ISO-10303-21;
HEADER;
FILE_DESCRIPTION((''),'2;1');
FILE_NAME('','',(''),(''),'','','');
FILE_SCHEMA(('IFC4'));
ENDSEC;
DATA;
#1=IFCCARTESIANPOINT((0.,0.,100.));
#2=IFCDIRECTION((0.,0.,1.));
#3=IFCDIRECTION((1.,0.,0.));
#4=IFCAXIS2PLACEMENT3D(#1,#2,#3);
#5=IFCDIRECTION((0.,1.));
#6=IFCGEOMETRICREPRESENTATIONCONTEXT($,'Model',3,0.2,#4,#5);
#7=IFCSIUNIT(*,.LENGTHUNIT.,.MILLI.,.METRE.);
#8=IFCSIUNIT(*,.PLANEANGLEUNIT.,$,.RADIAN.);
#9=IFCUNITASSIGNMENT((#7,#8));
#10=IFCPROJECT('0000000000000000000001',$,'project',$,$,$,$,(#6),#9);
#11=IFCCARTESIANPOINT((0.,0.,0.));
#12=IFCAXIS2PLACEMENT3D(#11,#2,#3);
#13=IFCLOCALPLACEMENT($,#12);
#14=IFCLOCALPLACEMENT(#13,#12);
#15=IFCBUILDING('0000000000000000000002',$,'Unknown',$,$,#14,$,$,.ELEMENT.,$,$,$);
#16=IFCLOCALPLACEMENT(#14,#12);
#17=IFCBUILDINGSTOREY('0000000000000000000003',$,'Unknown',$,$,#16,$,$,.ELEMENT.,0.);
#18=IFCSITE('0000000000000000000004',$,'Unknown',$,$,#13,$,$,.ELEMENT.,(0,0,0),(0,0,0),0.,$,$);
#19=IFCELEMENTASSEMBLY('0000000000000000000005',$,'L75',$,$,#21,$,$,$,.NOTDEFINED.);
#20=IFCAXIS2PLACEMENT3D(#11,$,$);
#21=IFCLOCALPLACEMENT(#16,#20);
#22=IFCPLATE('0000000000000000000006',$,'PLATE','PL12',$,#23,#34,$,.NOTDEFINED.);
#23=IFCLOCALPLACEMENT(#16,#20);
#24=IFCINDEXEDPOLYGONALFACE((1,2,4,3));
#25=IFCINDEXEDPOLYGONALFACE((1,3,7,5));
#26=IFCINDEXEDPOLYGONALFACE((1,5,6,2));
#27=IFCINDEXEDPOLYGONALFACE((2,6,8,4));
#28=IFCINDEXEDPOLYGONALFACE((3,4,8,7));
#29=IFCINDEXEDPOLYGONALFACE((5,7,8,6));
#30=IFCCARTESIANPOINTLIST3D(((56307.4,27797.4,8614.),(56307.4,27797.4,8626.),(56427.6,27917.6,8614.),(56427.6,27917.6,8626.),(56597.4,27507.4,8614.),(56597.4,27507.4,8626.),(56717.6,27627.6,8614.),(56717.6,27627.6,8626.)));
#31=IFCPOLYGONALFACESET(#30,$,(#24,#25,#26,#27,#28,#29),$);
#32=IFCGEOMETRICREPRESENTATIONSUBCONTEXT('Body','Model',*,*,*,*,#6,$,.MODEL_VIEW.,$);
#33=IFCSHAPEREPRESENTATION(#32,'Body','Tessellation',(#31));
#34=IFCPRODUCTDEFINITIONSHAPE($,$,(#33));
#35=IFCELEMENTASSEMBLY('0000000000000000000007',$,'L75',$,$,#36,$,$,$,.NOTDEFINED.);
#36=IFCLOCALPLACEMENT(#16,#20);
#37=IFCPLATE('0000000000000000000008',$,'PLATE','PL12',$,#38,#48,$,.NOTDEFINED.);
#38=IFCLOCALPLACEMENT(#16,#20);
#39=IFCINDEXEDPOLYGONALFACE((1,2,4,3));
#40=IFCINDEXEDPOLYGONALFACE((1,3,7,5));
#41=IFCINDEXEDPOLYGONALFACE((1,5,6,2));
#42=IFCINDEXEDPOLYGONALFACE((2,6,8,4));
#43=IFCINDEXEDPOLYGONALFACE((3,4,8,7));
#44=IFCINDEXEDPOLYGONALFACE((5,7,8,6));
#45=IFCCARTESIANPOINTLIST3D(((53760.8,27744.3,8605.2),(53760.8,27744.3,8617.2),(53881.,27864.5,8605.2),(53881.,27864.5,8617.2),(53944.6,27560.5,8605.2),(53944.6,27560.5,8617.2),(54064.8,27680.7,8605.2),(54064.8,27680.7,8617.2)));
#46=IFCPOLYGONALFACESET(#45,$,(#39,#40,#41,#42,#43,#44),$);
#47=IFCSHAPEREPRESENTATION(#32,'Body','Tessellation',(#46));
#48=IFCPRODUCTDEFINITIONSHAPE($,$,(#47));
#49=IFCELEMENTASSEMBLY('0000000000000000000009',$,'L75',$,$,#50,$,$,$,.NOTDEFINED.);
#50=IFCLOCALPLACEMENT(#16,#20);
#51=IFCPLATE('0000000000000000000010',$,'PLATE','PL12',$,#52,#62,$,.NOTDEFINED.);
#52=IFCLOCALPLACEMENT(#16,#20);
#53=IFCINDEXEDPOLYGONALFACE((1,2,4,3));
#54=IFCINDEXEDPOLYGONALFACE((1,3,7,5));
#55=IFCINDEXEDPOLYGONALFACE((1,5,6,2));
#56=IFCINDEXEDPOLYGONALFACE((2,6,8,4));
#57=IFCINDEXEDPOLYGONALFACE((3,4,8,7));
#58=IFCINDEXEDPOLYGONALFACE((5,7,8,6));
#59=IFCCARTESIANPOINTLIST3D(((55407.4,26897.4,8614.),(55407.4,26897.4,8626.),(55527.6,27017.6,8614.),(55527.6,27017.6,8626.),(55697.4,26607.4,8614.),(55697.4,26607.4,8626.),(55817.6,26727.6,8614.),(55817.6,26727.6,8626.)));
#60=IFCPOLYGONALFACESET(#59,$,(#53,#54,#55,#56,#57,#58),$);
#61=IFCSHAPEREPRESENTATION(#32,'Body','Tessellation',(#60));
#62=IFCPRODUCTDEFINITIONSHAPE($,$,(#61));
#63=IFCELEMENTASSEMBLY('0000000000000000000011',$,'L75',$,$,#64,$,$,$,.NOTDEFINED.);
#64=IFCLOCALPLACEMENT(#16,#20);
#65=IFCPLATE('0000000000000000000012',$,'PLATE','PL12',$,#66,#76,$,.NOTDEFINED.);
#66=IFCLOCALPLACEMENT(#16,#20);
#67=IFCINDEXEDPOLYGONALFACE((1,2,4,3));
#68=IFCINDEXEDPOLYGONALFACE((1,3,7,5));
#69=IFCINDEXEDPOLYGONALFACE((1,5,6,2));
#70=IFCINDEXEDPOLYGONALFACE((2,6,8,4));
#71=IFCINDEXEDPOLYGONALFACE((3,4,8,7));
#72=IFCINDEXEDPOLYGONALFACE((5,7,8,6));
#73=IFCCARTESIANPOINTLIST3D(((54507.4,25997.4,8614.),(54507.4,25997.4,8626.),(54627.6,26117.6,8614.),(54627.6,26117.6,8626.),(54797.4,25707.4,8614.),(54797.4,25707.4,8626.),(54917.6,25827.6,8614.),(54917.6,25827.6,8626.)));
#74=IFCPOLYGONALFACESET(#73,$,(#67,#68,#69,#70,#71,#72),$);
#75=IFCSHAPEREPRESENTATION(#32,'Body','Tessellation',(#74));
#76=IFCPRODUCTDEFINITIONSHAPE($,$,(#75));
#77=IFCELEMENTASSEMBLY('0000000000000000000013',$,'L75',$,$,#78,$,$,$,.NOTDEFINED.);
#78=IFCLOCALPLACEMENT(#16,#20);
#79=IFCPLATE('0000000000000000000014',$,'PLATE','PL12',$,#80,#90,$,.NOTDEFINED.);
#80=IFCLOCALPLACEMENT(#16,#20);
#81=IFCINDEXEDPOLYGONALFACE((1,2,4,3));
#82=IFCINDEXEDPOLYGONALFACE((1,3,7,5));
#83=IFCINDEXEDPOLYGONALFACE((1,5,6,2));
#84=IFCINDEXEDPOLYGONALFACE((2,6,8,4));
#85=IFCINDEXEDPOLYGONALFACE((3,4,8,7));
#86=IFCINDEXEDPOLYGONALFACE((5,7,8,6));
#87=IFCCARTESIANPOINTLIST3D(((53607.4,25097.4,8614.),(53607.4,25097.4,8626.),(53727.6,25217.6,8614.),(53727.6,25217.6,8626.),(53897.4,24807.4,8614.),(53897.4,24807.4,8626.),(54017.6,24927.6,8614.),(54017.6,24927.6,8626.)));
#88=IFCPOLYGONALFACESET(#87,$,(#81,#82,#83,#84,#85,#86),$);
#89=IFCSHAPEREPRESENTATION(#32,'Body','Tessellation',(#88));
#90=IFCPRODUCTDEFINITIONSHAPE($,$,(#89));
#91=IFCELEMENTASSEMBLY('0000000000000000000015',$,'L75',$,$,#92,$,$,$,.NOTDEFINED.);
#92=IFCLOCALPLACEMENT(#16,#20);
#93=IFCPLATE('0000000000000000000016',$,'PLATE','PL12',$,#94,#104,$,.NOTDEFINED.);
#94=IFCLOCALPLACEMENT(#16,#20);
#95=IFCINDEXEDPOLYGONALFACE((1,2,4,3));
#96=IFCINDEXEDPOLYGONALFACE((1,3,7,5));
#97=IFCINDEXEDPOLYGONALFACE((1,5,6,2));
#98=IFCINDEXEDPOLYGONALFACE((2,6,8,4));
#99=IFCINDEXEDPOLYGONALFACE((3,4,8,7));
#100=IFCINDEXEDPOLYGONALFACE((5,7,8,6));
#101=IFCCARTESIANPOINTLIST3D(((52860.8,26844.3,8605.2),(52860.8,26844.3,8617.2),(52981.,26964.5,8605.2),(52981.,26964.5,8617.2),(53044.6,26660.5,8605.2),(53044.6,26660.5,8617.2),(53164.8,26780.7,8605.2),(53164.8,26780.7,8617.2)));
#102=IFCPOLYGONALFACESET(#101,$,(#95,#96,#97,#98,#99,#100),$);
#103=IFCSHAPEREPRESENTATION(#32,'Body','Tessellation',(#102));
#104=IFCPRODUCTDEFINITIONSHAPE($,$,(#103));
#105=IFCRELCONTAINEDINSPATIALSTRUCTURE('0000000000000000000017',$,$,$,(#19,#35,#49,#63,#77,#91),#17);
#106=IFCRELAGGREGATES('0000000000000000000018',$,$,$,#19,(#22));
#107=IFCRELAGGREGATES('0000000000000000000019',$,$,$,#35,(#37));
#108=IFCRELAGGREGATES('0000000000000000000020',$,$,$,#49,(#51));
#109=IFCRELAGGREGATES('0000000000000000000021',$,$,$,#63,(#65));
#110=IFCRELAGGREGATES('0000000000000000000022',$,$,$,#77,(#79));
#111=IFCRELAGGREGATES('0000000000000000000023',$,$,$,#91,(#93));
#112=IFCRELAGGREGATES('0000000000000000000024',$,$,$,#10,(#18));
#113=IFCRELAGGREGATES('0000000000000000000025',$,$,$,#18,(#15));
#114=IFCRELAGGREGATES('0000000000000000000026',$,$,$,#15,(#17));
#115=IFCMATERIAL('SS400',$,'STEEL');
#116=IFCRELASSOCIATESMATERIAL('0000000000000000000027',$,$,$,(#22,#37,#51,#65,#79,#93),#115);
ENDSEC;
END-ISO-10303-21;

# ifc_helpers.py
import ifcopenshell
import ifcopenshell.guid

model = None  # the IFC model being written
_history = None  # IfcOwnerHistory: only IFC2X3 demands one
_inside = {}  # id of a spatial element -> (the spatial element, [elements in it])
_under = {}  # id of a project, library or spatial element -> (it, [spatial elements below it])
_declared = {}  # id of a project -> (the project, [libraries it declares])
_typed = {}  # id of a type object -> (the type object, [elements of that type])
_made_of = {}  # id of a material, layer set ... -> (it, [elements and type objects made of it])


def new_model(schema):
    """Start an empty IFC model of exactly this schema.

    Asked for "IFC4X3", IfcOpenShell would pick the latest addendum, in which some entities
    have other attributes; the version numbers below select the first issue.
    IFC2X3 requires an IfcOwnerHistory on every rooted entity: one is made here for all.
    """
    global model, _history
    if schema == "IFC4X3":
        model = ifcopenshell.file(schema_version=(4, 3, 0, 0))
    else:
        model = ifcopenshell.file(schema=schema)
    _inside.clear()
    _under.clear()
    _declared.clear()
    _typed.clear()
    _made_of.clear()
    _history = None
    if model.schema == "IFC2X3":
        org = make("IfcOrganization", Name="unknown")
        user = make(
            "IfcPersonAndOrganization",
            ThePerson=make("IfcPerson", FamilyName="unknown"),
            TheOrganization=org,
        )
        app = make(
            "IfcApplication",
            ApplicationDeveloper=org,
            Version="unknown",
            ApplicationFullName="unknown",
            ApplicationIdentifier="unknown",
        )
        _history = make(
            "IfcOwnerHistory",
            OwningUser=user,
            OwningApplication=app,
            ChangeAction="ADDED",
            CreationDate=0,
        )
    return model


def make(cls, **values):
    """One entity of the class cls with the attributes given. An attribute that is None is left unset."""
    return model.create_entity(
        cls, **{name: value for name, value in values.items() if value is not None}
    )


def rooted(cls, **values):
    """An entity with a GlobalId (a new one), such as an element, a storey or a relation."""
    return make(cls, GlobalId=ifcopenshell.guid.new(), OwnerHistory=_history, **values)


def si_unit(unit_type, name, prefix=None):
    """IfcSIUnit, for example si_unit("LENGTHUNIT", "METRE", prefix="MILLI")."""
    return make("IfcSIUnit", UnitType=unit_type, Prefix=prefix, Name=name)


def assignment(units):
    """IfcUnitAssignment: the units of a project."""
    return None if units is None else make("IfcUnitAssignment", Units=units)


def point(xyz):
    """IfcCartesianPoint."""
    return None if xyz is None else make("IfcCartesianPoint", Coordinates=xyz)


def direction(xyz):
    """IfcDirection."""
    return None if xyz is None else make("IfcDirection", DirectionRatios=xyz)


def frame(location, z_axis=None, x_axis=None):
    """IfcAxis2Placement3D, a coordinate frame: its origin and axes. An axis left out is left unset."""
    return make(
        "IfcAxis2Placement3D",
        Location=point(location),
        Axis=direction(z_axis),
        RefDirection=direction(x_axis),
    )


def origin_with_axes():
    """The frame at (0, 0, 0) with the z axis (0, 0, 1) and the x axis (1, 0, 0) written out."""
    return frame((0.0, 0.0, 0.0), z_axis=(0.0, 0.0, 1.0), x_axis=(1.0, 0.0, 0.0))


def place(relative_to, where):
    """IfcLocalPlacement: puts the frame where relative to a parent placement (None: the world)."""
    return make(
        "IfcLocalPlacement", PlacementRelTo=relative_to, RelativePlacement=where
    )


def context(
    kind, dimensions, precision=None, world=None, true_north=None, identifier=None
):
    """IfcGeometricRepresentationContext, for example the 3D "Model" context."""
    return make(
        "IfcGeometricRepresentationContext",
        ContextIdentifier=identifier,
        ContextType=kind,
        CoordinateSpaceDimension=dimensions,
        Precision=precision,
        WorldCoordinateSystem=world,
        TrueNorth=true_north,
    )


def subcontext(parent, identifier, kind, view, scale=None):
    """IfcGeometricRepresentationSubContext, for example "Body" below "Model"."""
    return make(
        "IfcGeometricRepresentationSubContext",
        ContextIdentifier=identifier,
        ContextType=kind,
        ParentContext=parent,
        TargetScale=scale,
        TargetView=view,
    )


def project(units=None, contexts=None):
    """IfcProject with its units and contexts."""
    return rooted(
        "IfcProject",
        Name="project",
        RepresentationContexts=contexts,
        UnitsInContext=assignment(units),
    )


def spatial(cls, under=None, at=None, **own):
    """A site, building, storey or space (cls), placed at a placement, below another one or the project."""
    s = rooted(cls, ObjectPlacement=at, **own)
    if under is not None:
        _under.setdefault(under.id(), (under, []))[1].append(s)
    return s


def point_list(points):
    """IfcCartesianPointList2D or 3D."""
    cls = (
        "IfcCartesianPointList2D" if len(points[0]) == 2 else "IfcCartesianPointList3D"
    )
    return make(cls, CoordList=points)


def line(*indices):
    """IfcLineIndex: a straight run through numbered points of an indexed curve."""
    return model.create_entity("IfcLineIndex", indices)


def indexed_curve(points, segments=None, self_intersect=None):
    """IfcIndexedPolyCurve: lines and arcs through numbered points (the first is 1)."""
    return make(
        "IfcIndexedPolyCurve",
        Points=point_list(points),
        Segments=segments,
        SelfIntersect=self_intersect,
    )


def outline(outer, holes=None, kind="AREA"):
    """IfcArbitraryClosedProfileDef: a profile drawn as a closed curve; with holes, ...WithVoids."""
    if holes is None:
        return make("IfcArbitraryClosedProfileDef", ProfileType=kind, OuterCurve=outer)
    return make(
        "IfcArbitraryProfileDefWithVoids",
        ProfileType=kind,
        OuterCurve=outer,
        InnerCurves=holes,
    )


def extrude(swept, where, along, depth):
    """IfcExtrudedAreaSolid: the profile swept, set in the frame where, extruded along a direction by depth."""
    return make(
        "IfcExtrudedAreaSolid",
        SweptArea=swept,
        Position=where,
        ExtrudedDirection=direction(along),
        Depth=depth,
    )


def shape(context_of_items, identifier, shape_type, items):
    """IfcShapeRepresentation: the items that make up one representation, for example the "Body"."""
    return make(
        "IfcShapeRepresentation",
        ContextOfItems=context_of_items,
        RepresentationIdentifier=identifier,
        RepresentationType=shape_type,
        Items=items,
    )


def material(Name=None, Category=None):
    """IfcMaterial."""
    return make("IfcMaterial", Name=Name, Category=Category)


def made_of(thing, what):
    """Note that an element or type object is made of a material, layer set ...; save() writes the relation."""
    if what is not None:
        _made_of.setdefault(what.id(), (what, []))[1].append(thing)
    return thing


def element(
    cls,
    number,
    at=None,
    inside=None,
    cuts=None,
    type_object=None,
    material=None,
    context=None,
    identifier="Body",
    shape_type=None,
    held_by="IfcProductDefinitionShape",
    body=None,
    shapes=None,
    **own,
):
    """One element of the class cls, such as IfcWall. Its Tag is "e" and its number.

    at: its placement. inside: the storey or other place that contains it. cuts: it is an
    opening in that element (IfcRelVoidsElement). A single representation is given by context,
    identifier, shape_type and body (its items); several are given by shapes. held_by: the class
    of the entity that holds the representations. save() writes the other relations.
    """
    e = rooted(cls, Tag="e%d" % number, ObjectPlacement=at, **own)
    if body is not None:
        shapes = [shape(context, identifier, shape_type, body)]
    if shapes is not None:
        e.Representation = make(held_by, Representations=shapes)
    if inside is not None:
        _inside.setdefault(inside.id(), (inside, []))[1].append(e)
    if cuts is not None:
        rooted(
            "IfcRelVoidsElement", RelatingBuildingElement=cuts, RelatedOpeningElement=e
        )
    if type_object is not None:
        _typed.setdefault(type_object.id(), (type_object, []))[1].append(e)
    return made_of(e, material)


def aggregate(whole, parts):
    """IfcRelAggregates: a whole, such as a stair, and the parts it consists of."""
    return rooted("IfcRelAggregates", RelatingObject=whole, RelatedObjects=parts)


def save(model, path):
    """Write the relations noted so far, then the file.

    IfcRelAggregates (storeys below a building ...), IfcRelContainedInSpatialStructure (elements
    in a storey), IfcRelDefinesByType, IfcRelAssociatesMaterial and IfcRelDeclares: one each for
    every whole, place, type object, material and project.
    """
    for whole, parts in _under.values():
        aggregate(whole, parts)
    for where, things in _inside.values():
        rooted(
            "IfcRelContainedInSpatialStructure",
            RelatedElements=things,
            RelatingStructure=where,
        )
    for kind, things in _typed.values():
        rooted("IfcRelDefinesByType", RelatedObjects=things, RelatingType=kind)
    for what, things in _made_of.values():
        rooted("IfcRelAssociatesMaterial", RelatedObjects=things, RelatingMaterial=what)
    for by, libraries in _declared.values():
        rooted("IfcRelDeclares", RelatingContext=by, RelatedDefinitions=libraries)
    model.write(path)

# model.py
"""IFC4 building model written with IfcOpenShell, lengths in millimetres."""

from ifc_helpers import new_model, si_unit, direction, frame, origin_with_axes, place, context, subcontext, project, spatial, line, indexed_curve, outline, extrude, material, element, aggregate, save


model = new_model("IFC4")

# Units and contexts
model_context = context("Model", 3, precision=0.2, world=frame((0.0, 0.0, 100.0), z_axis=(0.0, 0.0, 1.0), x_axis=(1.0, 0.0, 0.0)), true_north=direction((0.0, 1.0)))
body_context = subcontext(model_context, "Body", "Model", "MODEL_VIEW")
ifc_project = project(units=[si_unit("LENGTHUNIT", "METRE", prefix="MILLI"), si_unit("PLANEANGLEUNIT", "RADIAN")], contexts=[model_context])

# Site, building, storey
site_placement = place(None, origin_with_axes())
site = spatial("IfcSite", under=ifc_project, at=site_placement, Name="Unknown", CompositionType="ELEMENT", RefLatitude=(0, 0, 0), RefLongitude=(0, 0, 0), RefElevation=0.0)
building_placement = place(site_placement, origin_with_axes())
building = spatial("IfcBuilding", under=site, at=building_placement, Name="Unknown", CompositionType="ELEMENT")
storey_placement = place(building_placement, origin_with_axes())
storey = spatial("IfcBuildingStorey", under=building, at=storey_placement, Name="Unknown", CompositionType="ELEMENT", Elevation=0.0)

# Shared definitions
ifc_material_1 = material(Name="SS400", Category="STEEL")

# Element assemblies, plates
assembly_1_placement = place(storey_placement, frame((56512.5, 27712.5, 8355.0), z_axis=(1.0, 0.0, 0.0), x_axis=(0.0, 0.0, 1.0)))
assembly_1 = element("IfcElementAssembly", 1, at=assembly_1_placement, inside=storey, Name="L75", PredefinedType="NOTDEFINED")
plate_1_placement = place(assembly_1_placement, frame((265.0, 205.1, 84.9), z_axis=(1.0, 0.0, 0.0), x_axis=(0.0, -0.707107, 0.707107)))
plate_1 = element("IfcPlate", 2, at=plate_1_placement, material=ifc_material_1, Name="PLATE", Description="PL12", PredefinedType="NOTDEFINED", context=body_context, shape_type="SolidModel", body=[
    extrude(outline(indexed_curve([(0.0, 0.0), (170.0, 0.0), (170.0, 410.0), (0.0, 410.0)], segments=[line(1, 2, 3, 4, 1)])), frame((0.0, 0.0, 6.0), z_axis=(0.0, 0.0, 1.0), x_axis=(1.0, 0.0, 0.0)), (0.0, 0.0, -1.0), 12.0),
])
aggregate(assembly_1, [plate_1])
assembly_2_placement = place(storey_placement, frame((53912.8, 27712.5, 8355.2), z_axis=(1.0, 0.0, 0.0), x_axis=(0.0, 0.0, 1.0)))
assembly_2 = element("IfcElementAssembly", 3, at=assembly_2_placement, inside=storey, Name="L75", PredefinedType="NOTDEFINED")
plate_2_placement = place(assembly_2_placement, frame((256.0, 152.0, 31.8), z_axis=(1.0, 0.0, 0.0), x_axis=(0.0, -0.707107, 0.707107)))
plate_2 = element("IfcPlate", 4, at=plate_2_placement, material=ifc_material_1, Name="PLATE", Description="PL12", PredefinedType="NOTDEFINED", context=body_context, shape_type="SolidModel", body=[
    extrude(outline(indexed_curve([(0.0, 0.0), (170.0, 0.0), (170.0, 260.0), (0.0, 260.0)], segments=[line(1, 2, 3, 4, 1)])), frame((0.0, 0.0, 6.0), z_axis=(0.0, 0.0, 1.0), x_axis=(1.0, 0.0, 0.0)), (0.0, 0.0, -1.0), 12.0),
])
aggregate(assembly_2, [plate_2])
assembly_3_placement = place(storey_placement, frame((55612.5, 26812.5, 8355.0), z_axis=(1.0, 0.0, 0.0), x_axis=(0.0, 0.0, 1.0)))
assembly_3 = element("IfcElementAssembly", 5, at=assembly_3_placement, inside=storey, Name="L75", PredefinedType="NOTDEFINED")
plate_3_placement = place(assembly_3_placement, frame((265.0, 205.1, 84.9), z_axis=(1.0, 0.0, 0.0), x_axis=(0.0, -0.707107, 0.707107)))
plate_3 = element("IfcPlate", 6, at=plate_3_placement, material=ifc_material_1, Name="PLATE", Description="PL12", PredefinedType="NOTDEFINED", context=body_context, shape_type="SolidModel", body=[
    extrude(outline(indexed_curve([(0.0, 0.0), (170.0, 0.0), (170.0, 410.0), (0.0, 410.0)], segments=[line(1, 2, 3, 4, 1)])), frame((0.0, 0.0, 6.0), z_axis=(0.0, 0.0, 1.0), x_axis=(1.0, 0.0, 0.0)), (0.0, 0.0, -1.0), 12.0),
])
aggregate(assembly_3, [plate_3])
assembly_4_placement = place(storey_placement, frame((54712.5, 25912.5, 8355.0), z_axis=(1.0, 0.0, 0.0), x_axis=(0.0, 0.0, 1.0)))
assembly_4 = element("IfcElementAssembly", 7, at=assembly_4_placement, inside=storey, Name="L75", PredefinedType="NOTDEFINED")
plate_4_placement = place(assembly_4_placement, frame((265.0, 205.1, 84.9), z_axis=(1.0, 0.0, 0.0), x_axis=(0.0, -0.707107, 0.707107)))
plate_4 = element("IfcPlate", 8, at=plate_4_placement, material=ifc_material_1, Name="PLATE", Description="PL12", PredefinedType="NOTDEFINED", context=body_context, shape_type="SolidModel", body=[
    extrude(outline(indexed_curve([(0.0, 0.0), (170.0, 0.0), (170.0, 410.0), (0.0, 410.0)], segments=[line(1, 2, 3, 4, 1)])), frame((0.0, 0.0, 6.0), z_axis=(0.0, 0.0, 1.0), x_axis=(1.0, 0.0, 0.0)), (0.0, 0.0, -1.0), 12.0),
])
aggregate(assembly_4, [plate_4])
assembly_5_placement = place(storey_placement, frame((53812.5, 25012.5, 8355.0), z_axis=(1.0, 0.0, 0.0), x_axis=(0.0, 0.0, 1.0)))
assembly_5 = element("IfcElementAssembly", 9, at=assembly_5_placement, inside=storey, Name="L75", PredefinedType="NOTDEFINED")
plate_5_placement = place(assembly_5_placement, frame((265.0, 205.1, 84.9), z_axis=(1.0, 0.0, 0.0), x_axis=(0.0, -0.707107, 0.707107)))
plate_5 = element("IfcPlate", 10, at=plate_5_placement, material=ifc_material_1, Name="PLATE", Description="PL12", PredefinedType="NOTDEFINED", context=body_context, shape_type="SolidModel", body=[
    extrude(outline(indexed_curve([(0.0, 0.0), (170.0, 0.0), (170.0, 410.0), (0.0, 410.0)], segments=[line(1, 2, 3, 4, 1)])), frame((0.0, 0.0, 6.0), z_axis=(0.0, 0.0, 1.0), x_axis=(1.0, 0.0, 0.0)), (0.0, 0.0, -1.0), 12.0),
])
aggregate(assembly_5, [plate_5])
assembly_6_placement = place(storey_placement, frame((53012.8, 26812.5, 8355.2), z_axis=(1.0, 0.0, 0.0), x_axis=(0.0, 0.0, 1.0)))
assembly_6 = element("IfcElementAssembly", 11, at=assembly_6_placement, inside=storey, Name="L75", PredefinedType="NOTDEFINED")
plate_6_placement = place(assembly_6_placement, frame((256.0, 152.0, 31.8), z_axis=(1.0, 0.0, 0.0), x_axis=(0.0, -0.707107, 0.707107)))
plate_6 = element("IfcPlate", 12, at=plate_6_placement, material=ifc_material_1, Name="PLATE", Description="PL12", PredefinedType="NOTDEFINED", context=body_context, shape_type="SolidModel", body=[
    extrude(outline(indexed_curve([(0.0, 0.0), (170.0, 0.0), (170.0, 260.0), (0.0, 260.0)], segments=[line(1, 2, 3, 4, 1)])), frame((0.0, 0.0, 6.0), z_axis=(0.0, 0.0, 1.0), x_axis=(1.0, 0.0, 0.0)), (0.0, 0.0, -1.0), 12.0),
])
aggregate(assembly_6, [plate_6])

save(model, "model.ifc")
